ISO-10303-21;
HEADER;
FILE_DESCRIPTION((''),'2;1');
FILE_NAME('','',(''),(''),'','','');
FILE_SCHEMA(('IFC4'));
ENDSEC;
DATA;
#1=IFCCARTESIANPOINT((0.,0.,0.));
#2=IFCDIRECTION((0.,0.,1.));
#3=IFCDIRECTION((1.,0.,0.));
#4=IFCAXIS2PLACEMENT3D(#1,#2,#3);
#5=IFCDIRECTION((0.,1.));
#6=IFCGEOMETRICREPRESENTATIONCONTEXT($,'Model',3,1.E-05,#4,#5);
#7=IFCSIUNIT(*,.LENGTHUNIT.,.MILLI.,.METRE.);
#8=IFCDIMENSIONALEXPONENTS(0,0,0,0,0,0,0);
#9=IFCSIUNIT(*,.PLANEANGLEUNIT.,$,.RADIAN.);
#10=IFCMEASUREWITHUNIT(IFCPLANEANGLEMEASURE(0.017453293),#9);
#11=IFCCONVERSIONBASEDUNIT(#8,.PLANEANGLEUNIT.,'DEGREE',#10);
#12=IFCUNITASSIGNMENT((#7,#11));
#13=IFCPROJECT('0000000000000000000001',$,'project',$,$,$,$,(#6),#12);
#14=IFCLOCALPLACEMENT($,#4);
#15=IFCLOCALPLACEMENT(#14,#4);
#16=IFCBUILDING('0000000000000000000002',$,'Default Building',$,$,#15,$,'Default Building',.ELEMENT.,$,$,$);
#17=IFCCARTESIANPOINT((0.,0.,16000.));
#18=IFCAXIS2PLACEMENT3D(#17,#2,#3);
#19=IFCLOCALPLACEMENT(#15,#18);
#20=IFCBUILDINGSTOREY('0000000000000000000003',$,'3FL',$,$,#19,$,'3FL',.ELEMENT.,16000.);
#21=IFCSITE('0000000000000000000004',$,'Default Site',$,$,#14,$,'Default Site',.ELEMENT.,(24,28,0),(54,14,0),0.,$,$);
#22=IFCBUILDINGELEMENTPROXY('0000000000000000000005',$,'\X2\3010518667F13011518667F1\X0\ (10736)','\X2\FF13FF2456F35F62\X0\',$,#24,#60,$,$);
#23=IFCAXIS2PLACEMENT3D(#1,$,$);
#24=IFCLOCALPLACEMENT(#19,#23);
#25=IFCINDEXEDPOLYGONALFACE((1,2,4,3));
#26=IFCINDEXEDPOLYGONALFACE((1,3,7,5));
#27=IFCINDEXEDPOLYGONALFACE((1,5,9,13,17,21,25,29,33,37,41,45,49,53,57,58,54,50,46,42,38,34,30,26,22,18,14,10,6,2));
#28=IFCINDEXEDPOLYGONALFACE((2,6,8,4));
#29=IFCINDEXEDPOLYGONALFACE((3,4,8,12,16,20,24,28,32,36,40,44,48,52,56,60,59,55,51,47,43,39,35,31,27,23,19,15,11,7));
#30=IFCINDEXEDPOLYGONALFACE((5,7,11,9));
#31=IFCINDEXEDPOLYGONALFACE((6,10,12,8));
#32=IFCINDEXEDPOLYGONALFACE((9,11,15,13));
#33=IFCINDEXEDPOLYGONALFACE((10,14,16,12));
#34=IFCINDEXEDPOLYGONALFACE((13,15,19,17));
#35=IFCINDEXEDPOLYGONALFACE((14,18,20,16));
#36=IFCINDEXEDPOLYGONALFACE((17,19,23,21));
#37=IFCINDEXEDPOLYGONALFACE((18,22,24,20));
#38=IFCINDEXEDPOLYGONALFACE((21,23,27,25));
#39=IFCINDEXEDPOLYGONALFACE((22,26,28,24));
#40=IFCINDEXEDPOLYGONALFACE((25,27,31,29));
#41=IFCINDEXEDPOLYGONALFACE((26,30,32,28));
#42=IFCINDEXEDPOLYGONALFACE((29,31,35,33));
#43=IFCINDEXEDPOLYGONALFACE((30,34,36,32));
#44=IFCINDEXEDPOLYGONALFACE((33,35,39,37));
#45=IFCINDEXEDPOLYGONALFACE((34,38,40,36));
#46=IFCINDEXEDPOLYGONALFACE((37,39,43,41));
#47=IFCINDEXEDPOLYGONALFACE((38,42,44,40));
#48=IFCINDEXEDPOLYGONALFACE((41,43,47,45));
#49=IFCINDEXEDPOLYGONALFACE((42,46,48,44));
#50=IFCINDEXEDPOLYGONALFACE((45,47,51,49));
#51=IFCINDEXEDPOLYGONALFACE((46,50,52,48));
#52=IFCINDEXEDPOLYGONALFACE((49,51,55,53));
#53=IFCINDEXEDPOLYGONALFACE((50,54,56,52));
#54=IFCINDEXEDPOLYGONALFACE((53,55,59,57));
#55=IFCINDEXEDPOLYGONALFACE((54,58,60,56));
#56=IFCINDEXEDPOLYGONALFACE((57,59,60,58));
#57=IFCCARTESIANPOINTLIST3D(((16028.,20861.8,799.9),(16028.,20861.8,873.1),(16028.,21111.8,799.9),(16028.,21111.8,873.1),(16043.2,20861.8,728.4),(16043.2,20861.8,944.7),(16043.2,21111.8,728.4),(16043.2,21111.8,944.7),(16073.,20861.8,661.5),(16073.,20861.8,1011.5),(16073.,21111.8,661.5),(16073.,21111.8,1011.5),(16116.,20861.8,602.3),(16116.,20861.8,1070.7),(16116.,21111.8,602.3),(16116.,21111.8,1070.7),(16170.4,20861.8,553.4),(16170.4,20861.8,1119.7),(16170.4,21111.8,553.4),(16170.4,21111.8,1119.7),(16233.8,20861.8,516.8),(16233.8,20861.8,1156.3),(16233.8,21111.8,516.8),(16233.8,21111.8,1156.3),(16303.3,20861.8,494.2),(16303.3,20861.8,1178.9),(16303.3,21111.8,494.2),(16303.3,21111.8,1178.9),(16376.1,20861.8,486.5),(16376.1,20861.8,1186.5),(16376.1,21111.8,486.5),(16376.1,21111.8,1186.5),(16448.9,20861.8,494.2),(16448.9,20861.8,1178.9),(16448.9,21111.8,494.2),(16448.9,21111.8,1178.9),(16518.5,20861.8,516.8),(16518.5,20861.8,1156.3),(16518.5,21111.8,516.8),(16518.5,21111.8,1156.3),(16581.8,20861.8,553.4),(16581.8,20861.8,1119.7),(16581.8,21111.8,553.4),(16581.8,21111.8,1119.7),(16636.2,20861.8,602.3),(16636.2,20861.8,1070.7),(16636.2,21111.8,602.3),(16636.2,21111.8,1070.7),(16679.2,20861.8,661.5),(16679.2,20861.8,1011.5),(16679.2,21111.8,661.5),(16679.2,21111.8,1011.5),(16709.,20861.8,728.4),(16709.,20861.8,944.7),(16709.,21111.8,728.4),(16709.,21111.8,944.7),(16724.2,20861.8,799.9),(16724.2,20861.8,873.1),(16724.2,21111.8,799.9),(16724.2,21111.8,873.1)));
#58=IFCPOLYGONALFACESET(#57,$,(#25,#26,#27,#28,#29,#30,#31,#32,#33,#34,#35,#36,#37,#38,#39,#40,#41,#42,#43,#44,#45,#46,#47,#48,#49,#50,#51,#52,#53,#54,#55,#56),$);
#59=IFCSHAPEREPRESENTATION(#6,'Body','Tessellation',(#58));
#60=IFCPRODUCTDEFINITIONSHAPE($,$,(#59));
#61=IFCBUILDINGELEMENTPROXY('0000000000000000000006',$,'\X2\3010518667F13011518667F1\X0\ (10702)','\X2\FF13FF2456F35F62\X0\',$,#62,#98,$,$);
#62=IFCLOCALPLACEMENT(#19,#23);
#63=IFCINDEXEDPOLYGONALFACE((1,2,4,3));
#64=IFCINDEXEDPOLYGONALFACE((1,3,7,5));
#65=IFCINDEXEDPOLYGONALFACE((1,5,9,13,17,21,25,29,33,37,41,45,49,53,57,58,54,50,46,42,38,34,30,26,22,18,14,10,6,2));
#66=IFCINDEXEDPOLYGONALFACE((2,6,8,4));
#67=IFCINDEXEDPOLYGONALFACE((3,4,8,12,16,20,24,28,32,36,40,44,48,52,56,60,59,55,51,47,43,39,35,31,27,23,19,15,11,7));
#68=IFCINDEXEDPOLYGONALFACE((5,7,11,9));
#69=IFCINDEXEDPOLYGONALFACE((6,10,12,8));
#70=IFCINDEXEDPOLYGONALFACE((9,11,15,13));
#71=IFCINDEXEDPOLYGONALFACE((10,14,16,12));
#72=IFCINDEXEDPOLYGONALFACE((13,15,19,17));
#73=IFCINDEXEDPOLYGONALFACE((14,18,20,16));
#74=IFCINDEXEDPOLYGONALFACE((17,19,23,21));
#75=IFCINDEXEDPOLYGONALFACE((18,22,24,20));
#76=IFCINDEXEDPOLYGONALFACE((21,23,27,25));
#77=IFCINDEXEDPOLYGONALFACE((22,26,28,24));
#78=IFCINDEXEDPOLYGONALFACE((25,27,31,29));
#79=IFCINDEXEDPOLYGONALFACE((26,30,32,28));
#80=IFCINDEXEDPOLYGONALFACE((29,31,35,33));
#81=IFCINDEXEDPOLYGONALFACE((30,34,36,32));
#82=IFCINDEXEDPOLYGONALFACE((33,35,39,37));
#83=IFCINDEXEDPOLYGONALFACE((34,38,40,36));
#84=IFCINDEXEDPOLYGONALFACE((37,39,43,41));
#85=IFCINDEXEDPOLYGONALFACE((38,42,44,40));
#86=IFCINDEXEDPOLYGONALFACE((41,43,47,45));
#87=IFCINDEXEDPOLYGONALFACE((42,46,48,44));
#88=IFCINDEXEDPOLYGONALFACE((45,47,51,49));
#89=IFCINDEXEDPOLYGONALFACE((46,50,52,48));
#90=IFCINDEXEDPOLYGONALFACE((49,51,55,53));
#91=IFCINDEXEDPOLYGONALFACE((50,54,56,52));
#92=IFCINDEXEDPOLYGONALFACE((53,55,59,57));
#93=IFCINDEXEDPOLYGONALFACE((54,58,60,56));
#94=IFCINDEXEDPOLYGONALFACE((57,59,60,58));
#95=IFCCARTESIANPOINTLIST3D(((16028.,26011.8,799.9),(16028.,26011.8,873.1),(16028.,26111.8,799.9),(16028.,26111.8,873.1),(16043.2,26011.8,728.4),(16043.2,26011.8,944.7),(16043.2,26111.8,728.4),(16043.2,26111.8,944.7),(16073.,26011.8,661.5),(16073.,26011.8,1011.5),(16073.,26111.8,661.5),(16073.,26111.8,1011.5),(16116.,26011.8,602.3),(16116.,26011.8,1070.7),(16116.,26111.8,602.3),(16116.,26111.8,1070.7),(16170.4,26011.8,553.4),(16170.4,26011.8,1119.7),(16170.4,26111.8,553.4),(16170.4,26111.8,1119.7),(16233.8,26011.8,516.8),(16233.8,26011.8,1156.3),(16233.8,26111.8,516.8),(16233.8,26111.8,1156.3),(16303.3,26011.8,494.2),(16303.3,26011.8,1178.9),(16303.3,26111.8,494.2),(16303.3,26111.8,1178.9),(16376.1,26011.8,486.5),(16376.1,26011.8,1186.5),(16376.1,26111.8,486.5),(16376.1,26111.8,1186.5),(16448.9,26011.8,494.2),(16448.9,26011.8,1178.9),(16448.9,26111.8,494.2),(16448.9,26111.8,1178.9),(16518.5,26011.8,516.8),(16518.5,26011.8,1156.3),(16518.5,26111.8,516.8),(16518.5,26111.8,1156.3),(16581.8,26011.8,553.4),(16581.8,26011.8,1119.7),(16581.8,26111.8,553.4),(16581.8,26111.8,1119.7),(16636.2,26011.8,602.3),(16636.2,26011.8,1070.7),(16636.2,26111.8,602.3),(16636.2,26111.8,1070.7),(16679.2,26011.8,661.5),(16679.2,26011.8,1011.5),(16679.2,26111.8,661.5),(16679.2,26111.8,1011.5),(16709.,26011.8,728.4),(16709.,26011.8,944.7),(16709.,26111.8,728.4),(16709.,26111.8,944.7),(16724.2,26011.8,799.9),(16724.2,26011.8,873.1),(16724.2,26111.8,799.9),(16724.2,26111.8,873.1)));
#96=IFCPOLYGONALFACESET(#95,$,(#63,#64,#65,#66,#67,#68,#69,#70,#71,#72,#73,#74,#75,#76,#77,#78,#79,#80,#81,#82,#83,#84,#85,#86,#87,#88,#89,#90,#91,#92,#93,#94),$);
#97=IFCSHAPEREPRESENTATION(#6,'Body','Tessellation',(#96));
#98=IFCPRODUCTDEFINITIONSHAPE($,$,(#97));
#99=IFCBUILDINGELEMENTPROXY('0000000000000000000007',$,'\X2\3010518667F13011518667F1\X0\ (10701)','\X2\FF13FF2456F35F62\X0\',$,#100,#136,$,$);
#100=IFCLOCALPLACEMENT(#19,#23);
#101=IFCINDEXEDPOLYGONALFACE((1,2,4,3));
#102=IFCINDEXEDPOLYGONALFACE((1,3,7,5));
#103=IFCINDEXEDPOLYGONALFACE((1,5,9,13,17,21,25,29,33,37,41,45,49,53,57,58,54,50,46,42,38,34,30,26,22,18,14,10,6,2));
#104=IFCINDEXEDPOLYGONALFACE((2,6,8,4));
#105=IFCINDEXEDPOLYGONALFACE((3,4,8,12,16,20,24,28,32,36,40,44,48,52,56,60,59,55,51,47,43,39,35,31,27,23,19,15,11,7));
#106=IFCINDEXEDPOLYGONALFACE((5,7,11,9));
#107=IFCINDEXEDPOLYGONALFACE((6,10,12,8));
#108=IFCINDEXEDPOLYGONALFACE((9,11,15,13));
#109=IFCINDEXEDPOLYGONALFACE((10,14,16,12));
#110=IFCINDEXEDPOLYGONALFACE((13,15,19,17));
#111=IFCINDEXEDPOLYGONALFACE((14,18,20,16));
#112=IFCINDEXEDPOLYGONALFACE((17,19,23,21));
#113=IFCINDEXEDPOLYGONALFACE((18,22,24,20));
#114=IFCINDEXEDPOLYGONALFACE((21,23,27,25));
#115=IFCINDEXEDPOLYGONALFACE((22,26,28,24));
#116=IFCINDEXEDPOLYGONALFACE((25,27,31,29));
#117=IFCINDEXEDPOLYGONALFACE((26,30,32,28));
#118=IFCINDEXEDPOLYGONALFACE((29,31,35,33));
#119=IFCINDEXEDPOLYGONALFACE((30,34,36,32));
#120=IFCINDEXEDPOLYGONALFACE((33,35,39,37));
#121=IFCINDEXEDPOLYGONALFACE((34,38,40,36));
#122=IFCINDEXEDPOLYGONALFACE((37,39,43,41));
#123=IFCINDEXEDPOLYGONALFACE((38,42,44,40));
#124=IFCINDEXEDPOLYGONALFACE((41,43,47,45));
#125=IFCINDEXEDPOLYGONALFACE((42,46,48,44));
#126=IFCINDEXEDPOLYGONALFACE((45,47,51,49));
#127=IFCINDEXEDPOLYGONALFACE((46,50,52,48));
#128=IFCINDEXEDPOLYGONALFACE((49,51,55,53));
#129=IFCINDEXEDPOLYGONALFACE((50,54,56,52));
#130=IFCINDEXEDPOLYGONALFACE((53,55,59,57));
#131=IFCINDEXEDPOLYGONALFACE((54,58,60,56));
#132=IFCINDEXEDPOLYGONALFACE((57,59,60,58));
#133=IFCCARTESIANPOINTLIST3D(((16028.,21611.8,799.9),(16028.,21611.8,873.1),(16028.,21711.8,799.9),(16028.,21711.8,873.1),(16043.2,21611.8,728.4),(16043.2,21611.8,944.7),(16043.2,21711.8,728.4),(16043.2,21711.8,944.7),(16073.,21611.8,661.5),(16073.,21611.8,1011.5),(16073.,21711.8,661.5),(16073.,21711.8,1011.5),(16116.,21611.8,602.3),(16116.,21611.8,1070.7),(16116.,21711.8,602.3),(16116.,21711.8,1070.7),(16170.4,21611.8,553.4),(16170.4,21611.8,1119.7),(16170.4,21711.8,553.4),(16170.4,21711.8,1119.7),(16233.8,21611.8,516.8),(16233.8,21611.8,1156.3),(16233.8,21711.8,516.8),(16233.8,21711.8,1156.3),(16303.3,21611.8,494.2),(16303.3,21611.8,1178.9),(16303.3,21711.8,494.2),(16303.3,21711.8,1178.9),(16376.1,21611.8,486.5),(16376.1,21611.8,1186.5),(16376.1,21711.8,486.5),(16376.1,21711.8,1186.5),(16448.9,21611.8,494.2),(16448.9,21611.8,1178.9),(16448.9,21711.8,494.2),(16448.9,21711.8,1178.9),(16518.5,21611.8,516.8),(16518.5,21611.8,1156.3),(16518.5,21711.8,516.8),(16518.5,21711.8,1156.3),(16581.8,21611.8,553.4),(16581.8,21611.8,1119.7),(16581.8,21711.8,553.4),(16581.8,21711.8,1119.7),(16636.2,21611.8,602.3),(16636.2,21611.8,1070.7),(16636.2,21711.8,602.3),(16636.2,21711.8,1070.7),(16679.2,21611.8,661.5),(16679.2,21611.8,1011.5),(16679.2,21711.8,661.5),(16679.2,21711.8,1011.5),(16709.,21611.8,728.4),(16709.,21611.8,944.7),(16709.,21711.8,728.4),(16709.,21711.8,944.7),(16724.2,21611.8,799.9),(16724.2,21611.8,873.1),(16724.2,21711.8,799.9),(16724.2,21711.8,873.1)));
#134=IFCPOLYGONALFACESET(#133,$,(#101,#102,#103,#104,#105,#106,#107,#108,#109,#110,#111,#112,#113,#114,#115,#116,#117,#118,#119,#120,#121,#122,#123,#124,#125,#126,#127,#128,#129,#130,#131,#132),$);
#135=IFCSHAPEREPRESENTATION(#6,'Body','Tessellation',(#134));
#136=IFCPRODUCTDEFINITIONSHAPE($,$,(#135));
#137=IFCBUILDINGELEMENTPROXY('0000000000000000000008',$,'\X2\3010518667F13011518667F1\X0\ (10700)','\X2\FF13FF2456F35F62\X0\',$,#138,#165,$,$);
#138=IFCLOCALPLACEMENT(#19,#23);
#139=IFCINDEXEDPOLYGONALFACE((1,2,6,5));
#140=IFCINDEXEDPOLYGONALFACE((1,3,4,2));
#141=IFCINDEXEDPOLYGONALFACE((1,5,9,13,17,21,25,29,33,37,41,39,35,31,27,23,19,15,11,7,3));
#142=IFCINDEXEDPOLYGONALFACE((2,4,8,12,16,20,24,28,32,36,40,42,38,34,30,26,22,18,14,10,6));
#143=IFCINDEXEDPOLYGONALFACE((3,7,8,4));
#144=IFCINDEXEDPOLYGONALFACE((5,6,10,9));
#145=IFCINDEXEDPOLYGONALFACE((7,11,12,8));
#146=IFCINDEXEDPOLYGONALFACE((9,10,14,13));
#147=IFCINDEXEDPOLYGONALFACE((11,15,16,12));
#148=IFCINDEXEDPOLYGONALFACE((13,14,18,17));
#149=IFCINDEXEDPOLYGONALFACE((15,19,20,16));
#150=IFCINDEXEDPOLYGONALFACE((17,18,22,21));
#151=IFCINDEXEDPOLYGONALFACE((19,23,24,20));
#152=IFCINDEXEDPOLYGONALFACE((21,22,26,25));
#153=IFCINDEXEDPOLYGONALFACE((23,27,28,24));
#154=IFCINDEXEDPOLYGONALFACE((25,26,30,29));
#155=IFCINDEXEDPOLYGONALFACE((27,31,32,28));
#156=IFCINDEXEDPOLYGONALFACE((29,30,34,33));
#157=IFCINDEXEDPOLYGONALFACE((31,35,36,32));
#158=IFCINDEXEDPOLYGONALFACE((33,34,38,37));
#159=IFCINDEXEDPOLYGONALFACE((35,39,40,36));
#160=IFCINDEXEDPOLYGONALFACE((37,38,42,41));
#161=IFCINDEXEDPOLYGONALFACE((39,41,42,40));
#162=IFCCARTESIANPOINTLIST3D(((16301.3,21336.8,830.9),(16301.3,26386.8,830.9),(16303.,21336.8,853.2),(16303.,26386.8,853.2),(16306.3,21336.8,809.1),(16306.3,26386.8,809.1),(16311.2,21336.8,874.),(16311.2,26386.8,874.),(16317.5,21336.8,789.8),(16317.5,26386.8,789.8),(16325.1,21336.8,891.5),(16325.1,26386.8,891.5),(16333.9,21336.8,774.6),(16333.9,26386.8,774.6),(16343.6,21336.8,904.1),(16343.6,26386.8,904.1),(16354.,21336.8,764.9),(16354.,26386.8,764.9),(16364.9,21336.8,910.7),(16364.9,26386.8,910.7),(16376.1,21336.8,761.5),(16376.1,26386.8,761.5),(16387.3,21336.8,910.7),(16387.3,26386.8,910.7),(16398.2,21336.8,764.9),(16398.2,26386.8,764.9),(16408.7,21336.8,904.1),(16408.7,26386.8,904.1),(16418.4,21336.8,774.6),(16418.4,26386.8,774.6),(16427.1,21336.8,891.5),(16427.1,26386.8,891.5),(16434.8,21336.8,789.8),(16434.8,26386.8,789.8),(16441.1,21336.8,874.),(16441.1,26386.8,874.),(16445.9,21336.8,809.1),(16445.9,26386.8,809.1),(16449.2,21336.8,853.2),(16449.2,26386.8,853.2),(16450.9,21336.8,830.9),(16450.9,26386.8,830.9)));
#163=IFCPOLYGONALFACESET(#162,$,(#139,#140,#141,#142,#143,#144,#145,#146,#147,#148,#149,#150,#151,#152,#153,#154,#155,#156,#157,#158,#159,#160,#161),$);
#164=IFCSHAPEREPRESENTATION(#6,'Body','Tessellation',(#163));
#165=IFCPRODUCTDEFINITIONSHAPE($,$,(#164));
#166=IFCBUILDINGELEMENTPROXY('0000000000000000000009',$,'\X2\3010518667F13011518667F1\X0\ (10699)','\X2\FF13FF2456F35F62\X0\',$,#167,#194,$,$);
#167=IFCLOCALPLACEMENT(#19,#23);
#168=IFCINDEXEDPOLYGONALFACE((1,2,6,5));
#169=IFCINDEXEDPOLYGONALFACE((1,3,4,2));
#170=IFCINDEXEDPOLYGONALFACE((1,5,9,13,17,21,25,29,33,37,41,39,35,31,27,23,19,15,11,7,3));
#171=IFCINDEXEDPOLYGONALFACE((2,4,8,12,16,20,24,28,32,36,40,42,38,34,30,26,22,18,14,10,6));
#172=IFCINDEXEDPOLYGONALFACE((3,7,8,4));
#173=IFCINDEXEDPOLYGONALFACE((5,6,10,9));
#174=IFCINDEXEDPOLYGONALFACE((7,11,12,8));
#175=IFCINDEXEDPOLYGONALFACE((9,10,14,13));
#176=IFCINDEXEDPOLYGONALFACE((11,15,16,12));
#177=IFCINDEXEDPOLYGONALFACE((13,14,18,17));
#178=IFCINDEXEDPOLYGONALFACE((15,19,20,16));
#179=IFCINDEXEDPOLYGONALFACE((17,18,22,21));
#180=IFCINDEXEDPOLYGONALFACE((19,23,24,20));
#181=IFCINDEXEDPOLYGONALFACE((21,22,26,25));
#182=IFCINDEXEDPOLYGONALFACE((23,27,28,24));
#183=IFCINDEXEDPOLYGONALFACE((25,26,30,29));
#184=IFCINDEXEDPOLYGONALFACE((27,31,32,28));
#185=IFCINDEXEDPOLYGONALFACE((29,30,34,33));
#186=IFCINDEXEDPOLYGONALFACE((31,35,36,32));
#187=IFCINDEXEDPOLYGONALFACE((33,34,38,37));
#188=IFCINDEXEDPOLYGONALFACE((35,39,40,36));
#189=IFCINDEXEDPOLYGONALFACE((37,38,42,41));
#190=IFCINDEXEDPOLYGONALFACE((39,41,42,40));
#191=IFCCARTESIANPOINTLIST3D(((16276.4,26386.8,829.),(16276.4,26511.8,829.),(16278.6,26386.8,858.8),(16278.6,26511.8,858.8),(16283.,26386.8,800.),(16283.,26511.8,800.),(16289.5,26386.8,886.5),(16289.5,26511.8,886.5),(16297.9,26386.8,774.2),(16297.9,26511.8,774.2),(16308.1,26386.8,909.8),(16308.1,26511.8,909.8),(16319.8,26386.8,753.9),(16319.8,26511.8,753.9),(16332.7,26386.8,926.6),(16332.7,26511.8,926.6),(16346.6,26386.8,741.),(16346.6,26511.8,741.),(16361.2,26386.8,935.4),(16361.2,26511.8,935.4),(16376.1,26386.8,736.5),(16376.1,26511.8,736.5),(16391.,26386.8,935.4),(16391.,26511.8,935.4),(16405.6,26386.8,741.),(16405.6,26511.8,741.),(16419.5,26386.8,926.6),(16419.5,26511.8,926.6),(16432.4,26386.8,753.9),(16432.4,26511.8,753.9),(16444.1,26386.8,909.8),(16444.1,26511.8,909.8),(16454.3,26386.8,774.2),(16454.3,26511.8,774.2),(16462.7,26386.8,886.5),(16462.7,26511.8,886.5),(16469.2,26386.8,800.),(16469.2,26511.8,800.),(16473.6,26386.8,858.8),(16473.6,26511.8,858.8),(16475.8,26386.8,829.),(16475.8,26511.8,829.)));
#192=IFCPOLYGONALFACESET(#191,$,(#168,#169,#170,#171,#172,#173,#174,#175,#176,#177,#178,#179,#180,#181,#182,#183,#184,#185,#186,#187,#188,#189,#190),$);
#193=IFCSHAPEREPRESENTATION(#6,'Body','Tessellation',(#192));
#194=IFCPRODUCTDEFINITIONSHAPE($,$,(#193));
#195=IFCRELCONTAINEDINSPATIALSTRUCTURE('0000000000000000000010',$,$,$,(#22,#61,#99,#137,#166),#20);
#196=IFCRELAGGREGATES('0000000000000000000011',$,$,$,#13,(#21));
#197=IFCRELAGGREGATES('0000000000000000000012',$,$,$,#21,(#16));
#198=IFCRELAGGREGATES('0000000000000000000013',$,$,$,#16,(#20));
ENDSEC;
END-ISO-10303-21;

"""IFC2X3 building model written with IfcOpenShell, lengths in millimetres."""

from ifc_helpers import new_model, entity, si_unit, converted_unit, direction, frame, origin_with_axes, origin_2d_with_axis, place, context, project, spatial, circle, extrude, source, transform, mapped, element, save


model = new_model("IFC2X3")

# Units and contexts
model_context = context("Model", 3, precision=1e-05, world=origin_with_axes(), true_north=direction((0.0, 1.0)))
ifc_project = project(units=[si_unit("LENGTHUNIT", "METRE", prefix="MILLI"), converted_unit("PLANEANGLEUNIT", "DEGREE", entity("IfcPlaneAngleMeasure", 0.017453293), si_unit("PLANEANGLEUNIT", "RADIAN"), dimensions=[0, 0, 0, 0, 0, 0, 0])], contexts=[model_context])

# Site, building, storey
site_placement = place(None, origin_with_axes())
site = spatial("IfcSite", under=ifc_project, at=site_placement, Name="Default Site", LongName="Default Site", CompositionType="ELEMENT", RefLatitude=(24, 28, 0), RefLongitude=(54, 14, 0), RefElevation=0.0)
building_placement = place(site_placement, origin_with_axes())
building = spatial("IfcBuilding", under=site, at=building_placement, Name="Default Building", LongName="Default Building", CompositionType="ELEMENT")
storey_placement = place(building_placement, frame((0.0, 0.0, 16000.0), z_axis=(0.0, 0.0, 1.0), x_axis=(1.0, 0.0, 0.0)))
storey = spatial("IfcBuildingStorey", under=building, at=storey_placement, Name="3FL", LongName="3FL", CompositionType="ELEMENT", Elevation=16000.0)

# Building element proxies
shared_shape_1 = source(origin_with_axes(), model_context, "Body", "SweptSolid", [
    extrude(circle(Radius=350.0, at=origin_2d_with_axis()), frame((0.0, 0.0, 0.0), z_axis=(0.0, 0.0, 1.0), x_axis=(1.0, 0.0, 0.0)), (0.0, 0.0, 1.0), 250.0),
])
proxy_1_placement = place(storey_placement, frame((16376.1, 20861.8, 836.5), z_axis=(0.0, 1.0, 0.0), x_axis=(0.0, 0.0, -1.0)))
element("IfcBuildingElementProxy", 1, at=proxy_1_placement, inside=storey, Name="【円柱】円柱 (10736)", Description="３Ｄ図形", context=model_context, shape_type="MappedRepresentation", body=[
    mapped(shared_shape_1, transform((0.0, 0.0, 0.0))),
])
shared_shape_2 = source(origin_with_axes(), model_context, "Body", "SweptSolid", [
    extrude(circle(Radius=350.0, at=origin_2d_with_axis()), frame((0.0, 0.0, 0.0), z_axis=(0.0, 0.0, 1.0), x_axis=(1.0, 0.0, 0.0)), (0.0, 0.0, 1.0), 100.0),
])
proxy_2_placement = place(storey_placement, frame((16376.1, 26011.8, 836.5), z_axis=(0.0, 1.0, 0.0), x_axis=(0.0, 0.0, -1.0)))
element("IfcBuildingElementProxy", 2, at=proxy_2_placement, inside=storey, Name="【円柱】円柱 (10702)", Description="３Ｄ図形", context=model_context, shape_type="MappedRepresentation", body=[
    mapped(shared_shape_2, transform((0.0, 0.0, 0.0))),
])
shared_shape_3 = source(origin_with_axes(), model_context, "Body", "SweptSolid", [
    extrude(circle(Radius=350.0, at=origin_2d_with_axis()), frame((0.0, 0.0, 0.0), z_axis=(0.0, 0.0, 1.0), x_axis=(1.0, 0.0, 0.0)), (0.0, 0.0, 1.0), 100.0),
])
proxy_3_placement = place(storey_placement, frame((16376.1, 21611.8, 836.5), z_axis=(0.0, 1.0, 0.0), x_axis=(0.0, 0.0, -1.0)))
element("IfcBuildingElementProxy", 3, at=proxy_3_placement, inside=storey, Name="【円柱】円柱 (10701)", Description="３Ｄ図形", context=model_context, shape_type="MappedRepresentation", body=[
    mapped(shared_shape_3, transform((0.0, 0.0, 0.0))),
])
shared_shape_4 = source(origin_with_axes(), model_context, "Body", "SweptSolid", [
    extrude(circle(Radius=75.0, at=origin_2d_with_axis()), frame((0.0, 0.0, 0.0), z_axis=(0.0, 0.0, 1.0), x_axis=(1.0, 0.0, 0.0)), (0.0, 0.0, 1.0), 5050.0),
])
proxy_4_placement = place(storey_placement, frame((16376.1, 21336.8, 836.5), z_axis=(0.0, 1.0, 0.0), x_axis=(0.0, 0.0, -1.0)))
element("IfcBuildingElementProxy", 4, at=proxy_4_placement, inside=storey, Name="【円柱】円柱 (10700)", Description="３Ｄ図形", context=model_context, shape_type="MappedRepresentation", body=[
    mapped(shared_shape_4, transform((0.0, 0.0, 0.0))),
])
shared_shape_5 = source(origin_with_axes(), model_context, "Body", "SweptSolid", [
    extrude(circle(Radius=100.0, at=origin_2d_with_axis()), frame((0.0, 0.0, 0.0), z_axis=(0.0, 0.0, 1.0), x_axis=(1.0, 0.0, 0.0)), (0.0, 0.0, 1.0), 125.0),
])
proxy_5_placement = place(storey_placement, frame((16376.1, 26386.8, 836.5), z_axis=(0.0, 1.0, 0.0), x_axis=(0.0, 0.0, -1.0)))
element("IfcBuildingElementProxy", 5, at=proxy_5_placement, inside=storey, Name="【円柱】円柱 (10699)", Description="３Ｄ図形", context=model_context, shape_type="MappedRepresentation", body=[
    mapped(shared_shape_5, transform((0.0, 0.0, 0.0))),
])

save(model, "model.ifc")
